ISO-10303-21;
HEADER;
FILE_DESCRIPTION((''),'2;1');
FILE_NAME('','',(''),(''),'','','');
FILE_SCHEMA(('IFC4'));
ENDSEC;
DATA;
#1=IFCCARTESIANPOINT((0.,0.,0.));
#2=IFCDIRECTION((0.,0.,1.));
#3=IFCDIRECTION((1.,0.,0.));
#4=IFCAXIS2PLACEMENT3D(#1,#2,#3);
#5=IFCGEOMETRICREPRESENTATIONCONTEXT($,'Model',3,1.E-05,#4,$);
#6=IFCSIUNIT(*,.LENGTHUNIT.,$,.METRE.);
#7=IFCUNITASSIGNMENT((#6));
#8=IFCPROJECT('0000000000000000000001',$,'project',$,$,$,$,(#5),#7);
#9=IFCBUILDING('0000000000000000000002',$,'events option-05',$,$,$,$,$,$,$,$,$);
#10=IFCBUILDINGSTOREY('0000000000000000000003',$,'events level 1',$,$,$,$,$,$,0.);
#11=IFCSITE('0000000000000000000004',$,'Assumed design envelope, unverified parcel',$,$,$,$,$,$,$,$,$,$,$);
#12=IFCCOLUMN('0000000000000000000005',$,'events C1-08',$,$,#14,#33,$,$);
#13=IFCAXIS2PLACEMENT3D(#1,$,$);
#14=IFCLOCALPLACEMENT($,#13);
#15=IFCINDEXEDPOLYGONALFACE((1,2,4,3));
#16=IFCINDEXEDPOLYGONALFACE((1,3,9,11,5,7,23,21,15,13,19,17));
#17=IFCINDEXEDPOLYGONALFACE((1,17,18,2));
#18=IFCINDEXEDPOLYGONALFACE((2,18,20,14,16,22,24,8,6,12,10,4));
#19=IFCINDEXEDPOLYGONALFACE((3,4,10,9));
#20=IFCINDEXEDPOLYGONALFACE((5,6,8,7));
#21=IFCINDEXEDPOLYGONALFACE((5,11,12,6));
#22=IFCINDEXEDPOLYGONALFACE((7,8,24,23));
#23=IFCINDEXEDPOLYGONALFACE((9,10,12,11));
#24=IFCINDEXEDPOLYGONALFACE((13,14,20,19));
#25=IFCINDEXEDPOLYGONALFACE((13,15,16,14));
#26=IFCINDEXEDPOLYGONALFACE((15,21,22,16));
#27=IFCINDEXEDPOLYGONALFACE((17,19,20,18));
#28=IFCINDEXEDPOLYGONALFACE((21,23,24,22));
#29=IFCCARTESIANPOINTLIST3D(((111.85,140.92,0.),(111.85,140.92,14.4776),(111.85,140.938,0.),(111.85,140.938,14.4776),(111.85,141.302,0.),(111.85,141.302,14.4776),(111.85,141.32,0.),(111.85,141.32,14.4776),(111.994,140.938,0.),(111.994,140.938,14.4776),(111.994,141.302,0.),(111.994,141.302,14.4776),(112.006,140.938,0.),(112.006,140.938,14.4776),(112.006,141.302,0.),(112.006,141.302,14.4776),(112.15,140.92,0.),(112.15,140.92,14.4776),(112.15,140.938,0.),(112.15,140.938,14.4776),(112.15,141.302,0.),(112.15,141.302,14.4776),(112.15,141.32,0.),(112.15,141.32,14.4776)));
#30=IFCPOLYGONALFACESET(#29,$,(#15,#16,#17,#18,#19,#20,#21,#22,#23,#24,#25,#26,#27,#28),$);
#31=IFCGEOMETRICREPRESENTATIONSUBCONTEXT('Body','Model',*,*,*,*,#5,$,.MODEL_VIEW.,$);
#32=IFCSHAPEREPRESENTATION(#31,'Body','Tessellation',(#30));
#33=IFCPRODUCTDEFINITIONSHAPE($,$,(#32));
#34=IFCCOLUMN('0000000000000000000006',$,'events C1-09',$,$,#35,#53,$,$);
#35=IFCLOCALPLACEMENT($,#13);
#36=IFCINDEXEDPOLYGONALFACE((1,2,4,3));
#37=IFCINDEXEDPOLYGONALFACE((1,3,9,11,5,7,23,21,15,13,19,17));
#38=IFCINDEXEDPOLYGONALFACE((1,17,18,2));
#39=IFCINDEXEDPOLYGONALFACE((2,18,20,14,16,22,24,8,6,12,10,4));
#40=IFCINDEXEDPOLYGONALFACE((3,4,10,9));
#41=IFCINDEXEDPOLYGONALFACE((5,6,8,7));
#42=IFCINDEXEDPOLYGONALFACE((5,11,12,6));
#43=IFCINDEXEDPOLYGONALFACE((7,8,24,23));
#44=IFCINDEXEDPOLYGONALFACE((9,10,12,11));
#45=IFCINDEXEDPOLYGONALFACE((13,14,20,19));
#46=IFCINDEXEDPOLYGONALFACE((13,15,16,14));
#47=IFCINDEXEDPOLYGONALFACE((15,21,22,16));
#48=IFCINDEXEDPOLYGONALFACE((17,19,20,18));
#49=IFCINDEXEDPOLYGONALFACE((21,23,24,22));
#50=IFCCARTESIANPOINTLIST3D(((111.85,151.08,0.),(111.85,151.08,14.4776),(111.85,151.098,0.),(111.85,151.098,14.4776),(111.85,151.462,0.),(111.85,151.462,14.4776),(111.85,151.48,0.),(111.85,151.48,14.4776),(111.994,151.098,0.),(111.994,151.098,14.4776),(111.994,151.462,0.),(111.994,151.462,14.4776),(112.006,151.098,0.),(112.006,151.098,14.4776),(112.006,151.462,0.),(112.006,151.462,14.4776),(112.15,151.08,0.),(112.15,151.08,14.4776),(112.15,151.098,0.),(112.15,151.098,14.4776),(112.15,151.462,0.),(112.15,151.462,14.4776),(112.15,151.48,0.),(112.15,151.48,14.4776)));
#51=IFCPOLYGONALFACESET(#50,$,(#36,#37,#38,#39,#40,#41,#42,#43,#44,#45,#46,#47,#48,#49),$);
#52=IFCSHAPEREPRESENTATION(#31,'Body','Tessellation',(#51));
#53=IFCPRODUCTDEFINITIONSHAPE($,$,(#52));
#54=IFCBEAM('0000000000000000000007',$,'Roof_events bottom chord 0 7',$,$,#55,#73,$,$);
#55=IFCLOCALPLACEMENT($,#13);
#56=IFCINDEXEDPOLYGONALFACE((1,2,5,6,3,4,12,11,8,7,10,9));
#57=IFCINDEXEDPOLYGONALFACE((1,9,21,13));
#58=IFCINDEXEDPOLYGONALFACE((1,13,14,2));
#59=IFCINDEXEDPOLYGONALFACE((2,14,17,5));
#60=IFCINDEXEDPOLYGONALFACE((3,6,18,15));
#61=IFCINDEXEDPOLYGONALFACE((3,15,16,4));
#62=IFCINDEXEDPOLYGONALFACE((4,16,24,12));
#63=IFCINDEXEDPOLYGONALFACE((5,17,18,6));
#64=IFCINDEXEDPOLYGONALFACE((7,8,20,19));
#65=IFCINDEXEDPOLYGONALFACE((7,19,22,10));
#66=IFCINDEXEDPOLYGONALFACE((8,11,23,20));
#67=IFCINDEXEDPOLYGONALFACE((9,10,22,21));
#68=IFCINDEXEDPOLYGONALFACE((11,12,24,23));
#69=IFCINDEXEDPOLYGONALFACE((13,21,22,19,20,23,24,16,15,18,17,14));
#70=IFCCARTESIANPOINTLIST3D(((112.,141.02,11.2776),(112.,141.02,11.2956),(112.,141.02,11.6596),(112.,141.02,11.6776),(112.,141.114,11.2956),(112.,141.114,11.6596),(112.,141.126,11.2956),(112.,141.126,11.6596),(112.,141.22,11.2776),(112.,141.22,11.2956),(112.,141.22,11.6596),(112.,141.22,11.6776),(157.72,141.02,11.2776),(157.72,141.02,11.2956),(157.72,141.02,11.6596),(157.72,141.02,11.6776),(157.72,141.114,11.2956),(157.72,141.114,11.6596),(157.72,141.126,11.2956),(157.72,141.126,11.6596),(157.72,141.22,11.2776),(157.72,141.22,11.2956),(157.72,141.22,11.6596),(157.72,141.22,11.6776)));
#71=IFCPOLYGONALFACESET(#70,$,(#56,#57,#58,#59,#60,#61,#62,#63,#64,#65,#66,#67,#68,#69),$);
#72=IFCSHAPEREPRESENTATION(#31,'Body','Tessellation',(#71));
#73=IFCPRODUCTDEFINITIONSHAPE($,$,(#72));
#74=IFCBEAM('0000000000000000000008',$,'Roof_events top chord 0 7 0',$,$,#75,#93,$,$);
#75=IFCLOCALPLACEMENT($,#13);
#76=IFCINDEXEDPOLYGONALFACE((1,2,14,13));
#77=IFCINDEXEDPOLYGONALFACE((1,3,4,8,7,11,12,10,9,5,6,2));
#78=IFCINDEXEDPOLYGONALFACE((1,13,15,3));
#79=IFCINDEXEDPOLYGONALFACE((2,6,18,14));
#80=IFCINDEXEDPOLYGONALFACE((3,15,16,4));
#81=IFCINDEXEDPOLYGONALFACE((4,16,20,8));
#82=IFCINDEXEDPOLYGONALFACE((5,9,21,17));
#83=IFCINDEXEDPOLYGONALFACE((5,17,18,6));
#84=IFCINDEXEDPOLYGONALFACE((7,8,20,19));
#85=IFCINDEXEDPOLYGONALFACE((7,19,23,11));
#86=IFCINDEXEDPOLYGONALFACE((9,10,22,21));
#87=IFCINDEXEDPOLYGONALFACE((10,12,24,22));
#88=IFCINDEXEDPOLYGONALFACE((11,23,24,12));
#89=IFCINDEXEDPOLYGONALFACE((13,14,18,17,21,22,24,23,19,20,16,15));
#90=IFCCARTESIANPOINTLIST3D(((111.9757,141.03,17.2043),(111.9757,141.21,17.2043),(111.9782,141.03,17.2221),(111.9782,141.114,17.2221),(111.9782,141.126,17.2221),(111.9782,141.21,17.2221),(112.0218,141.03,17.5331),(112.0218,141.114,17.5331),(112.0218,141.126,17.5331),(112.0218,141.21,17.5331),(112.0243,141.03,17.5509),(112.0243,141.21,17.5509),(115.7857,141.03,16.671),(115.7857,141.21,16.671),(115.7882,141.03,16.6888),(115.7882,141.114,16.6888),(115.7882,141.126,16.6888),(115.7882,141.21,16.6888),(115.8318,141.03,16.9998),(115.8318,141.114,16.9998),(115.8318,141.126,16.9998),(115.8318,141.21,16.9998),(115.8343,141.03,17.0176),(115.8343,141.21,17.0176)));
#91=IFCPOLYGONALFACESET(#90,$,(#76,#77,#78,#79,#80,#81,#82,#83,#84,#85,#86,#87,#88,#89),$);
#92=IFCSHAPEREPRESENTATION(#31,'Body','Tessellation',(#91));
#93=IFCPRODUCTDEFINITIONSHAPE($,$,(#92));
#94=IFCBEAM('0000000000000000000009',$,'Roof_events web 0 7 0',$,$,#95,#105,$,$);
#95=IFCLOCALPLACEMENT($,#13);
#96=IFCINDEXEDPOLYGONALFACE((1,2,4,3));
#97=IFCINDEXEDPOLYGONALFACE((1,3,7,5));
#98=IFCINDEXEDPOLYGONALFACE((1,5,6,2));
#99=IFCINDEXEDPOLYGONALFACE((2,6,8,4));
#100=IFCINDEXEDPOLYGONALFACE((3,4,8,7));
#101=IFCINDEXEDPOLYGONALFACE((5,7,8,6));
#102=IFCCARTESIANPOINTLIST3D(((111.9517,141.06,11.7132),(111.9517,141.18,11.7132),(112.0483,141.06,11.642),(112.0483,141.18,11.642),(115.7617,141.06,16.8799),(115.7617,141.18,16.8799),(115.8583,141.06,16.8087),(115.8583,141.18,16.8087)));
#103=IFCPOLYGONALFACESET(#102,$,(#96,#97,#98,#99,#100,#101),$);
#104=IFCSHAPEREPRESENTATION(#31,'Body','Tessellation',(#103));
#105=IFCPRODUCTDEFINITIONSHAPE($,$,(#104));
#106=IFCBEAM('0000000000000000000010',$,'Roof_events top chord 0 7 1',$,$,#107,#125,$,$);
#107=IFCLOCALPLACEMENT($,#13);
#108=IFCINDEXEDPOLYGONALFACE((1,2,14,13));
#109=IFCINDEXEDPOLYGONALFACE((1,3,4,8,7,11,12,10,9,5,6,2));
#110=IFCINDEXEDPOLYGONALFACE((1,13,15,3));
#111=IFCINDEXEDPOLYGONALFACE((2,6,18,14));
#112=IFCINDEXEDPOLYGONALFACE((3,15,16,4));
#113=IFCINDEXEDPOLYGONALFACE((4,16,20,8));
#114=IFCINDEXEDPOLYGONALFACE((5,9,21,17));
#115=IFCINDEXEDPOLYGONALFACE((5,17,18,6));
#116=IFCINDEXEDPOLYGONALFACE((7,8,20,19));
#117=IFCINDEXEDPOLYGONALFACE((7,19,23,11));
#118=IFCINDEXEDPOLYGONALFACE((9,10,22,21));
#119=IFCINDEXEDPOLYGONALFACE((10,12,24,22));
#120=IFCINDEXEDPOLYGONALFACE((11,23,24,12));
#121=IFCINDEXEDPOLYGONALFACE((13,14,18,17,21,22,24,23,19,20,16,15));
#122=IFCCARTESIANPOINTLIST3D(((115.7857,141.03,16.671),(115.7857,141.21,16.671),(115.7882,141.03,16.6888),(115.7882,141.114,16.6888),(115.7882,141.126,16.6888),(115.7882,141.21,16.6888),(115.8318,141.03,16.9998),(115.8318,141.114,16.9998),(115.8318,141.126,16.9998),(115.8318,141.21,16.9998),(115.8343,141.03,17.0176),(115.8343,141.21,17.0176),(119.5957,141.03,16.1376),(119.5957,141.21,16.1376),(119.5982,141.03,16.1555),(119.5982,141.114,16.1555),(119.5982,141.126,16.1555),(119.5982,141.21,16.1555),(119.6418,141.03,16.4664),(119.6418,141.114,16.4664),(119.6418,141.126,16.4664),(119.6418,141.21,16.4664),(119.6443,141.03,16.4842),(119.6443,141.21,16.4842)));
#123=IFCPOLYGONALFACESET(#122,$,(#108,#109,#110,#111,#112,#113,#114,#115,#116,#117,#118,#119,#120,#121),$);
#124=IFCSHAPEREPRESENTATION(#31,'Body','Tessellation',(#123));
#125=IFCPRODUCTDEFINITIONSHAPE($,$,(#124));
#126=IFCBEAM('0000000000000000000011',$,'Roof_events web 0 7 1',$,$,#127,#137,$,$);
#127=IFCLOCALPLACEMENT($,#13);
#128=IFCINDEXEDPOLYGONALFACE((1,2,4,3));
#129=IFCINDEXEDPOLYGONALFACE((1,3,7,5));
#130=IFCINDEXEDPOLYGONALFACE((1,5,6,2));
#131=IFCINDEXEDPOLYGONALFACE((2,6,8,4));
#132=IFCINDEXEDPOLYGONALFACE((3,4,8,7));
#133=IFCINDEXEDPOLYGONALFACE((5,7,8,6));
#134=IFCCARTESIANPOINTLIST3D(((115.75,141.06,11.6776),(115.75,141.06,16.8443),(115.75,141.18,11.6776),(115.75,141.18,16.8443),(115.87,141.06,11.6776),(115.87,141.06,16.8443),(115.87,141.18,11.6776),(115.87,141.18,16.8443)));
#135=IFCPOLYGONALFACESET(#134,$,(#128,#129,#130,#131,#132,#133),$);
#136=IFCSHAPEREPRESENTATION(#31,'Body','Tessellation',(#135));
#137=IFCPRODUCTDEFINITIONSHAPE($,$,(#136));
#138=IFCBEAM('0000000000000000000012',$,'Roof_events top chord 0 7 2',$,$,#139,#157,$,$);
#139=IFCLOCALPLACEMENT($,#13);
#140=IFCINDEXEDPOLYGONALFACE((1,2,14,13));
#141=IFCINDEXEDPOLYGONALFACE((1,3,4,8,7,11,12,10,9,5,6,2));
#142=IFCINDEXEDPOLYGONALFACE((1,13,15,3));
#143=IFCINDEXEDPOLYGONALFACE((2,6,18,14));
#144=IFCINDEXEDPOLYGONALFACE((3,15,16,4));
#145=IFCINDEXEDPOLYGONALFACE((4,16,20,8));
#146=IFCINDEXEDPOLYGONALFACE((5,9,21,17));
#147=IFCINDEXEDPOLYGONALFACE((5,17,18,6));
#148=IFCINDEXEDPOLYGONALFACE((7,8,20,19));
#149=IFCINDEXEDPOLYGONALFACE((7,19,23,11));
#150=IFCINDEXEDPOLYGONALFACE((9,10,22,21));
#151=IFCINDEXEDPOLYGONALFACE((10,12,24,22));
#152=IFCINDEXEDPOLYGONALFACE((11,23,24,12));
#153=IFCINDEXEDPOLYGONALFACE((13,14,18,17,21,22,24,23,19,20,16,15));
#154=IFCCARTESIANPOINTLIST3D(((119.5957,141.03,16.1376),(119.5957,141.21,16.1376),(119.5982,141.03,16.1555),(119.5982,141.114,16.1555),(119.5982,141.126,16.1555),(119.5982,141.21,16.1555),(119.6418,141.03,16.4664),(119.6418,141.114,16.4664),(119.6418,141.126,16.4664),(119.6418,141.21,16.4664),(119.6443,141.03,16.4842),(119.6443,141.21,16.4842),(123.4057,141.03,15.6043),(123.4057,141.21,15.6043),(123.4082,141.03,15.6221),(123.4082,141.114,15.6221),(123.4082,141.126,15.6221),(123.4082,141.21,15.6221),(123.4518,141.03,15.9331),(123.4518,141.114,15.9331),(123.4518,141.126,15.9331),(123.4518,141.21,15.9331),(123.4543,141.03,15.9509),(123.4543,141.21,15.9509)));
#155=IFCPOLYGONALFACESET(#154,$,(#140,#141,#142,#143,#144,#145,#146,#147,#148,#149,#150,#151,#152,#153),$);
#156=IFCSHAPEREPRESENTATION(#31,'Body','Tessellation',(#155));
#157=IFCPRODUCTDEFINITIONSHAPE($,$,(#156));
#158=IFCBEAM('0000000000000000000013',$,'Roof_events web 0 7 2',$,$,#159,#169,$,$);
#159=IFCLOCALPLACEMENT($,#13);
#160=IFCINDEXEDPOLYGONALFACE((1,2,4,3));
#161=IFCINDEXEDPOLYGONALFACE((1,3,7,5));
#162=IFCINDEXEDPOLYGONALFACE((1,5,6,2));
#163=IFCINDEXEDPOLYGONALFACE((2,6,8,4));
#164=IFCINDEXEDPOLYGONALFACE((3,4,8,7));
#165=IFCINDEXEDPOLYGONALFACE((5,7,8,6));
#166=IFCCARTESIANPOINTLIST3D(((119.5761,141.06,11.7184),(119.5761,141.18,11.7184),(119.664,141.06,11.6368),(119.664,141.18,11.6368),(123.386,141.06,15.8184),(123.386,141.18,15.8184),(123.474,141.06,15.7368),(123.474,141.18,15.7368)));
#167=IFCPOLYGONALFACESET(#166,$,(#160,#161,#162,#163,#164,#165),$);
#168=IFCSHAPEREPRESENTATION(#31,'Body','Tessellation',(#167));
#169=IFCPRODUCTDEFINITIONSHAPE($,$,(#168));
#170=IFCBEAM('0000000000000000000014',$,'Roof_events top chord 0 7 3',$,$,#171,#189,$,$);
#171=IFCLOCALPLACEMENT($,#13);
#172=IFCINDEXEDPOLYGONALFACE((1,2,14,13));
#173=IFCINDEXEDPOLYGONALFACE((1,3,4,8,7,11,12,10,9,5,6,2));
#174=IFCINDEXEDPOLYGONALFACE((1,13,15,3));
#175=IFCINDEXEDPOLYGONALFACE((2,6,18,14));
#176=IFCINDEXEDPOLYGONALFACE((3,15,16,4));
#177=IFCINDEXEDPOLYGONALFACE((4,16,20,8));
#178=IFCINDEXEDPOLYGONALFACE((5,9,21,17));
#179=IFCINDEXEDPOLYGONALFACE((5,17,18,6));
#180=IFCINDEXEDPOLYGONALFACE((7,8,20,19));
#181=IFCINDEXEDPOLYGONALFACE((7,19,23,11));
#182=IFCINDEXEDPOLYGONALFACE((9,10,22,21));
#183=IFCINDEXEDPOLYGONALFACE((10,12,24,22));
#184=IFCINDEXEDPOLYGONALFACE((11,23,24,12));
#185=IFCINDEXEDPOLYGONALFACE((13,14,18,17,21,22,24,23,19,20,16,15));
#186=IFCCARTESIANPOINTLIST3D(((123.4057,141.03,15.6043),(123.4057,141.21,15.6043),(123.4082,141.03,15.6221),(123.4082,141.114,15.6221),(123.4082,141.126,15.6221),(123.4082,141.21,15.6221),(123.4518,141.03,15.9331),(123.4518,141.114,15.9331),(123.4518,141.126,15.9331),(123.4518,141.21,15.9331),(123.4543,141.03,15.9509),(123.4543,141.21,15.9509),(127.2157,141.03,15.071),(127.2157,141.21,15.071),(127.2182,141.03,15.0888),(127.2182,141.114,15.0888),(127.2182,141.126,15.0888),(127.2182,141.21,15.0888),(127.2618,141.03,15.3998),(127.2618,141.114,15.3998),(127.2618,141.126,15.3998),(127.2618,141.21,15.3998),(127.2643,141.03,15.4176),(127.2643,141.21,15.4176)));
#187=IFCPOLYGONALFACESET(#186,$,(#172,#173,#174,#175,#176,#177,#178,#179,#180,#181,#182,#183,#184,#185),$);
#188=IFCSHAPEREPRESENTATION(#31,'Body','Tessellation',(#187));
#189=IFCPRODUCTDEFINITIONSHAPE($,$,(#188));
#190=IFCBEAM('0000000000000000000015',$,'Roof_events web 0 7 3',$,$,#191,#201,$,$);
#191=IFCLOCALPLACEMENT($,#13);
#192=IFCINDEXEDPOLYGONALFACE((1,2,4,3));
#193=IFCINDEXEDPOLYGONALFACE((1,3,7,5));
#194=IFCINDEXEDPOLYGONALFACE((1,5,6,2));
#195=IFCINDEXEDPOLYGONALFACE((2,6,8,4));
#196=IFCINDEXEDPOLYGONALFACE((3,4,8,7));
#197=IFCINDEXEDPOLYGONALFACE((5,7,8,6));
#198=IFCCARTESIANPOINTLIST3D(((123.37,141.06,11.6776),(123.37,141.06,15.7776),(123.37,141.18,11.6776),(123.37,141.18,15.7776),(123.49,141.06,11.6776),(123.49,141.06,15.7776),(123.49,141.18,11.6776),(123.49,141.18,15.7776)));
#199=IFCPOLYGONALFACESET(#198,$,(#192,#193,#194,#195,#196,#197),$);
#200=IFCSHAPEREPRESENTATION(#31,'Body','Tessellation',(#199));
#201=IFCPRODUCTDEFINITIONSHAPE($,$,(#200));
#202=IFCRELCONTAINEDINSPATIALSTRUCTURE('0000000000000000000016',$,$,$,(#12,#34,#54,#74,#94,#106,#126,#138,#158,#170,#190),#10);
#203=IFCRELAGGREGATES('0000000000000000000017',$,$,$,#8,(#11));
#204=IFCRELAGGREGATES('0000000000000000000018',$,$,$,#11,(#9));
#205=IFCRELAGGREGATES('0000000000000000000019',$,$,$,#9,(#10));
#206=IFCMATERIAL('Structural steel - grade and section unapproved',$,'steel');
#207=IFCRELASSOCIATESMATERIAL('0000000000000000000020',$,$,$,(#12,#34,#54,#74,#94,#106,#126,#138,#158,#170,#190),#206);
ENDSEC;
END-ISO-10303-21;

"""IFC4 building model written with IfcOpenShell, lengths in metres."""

from ifc_helpers import new_model, si_unit, frame, origin_with_axes, place, context, subcontext, project, spatial, rectangle, i_section, extrude, material, element, save


model = new_model("IFC4")

# Units and contexts
model_context = context("Model", 3, precision=1e-05, world=origin_with_axes())
body_context = subcontext(model_context, "Body", "Model", "MODEL_VIEW")
ifc_project = project(units=[si_unit("LENGTHUNIT", "METRE")], contexts=[model_context])

# Site, building, storey
site = spatial("IfcSite", under=ifc_project, Name="Assumed design envelope, unverified parcel")
building = spatial("IfcBuilding", under=site, Name="events option-05")
storey = spatial("IfcBuildingStorey", under=building, Name="events level 1", Elevation=0.0)

# Columns
ifc_material_1 = material(Name="Structural steel - grade and section unapproved", Category="steel")
for number, where, z_axis, x_axis, name in (
    (1, (112.0, 141.12, 0.0), (0.0, 0.0, 1.0), (-1.0, 0.0, 0.0), "events C1-08"),
    (2, (112.0, 151.28, 0.0), (0.0, 0.0, 1.0), (-1.0, 0.0, 0.0), "events C1-09"),
):
    element("IfcColumn", number, at=place(None, frame(where, z_axis=z_axis, x_axis=x_axis)), inside=storey, material=ifc_material_1, Name=name, context=body_context, shape_type="SweptSolid", body=[
        extrude(i_section(OverallWidth=0.3, OverallDepth=0.4, WebThickness=0.012, FlangeThickness=0.018, FilletRadius=0.0), origin_with_axes(), (0.0, 0.0, 1.0), 14.4776),
    ])

# Beams
beam_1_placement = place(None, frame((112.0, 141.12, 11.4776), z_axis=(1.0, 0.0, 0.0), x_axis=(0.0, 1.0, 0.0)))
element("IfcBeam", 3, at=beam_1_placement, inside=storey, material=ifc_material_1, Name="Roof_events bottom chord 0 7", context=body_context, shape_type="SweptSolid", body=[
    extrude(i_section(OverallWidth=0.2, OverallDepth=0.4, WebThickness=0.012, FlangeThickness=0.018, FilletRadius=0.0), origin_with_axes(), (0.0, 0.0, 1.0), 45.72),
])
beam_2_placement = place(None, frame((112.0, 141.12, 17.3776), z_axis=(0.990344, 0.0, -0.138631), x_axis=(0.0, 1.0, 0.0)))
element("IfcBeam", 4, at=beam_2_placement, inside=storey, material=ifc_material_1, Name="Roof_events top chord 0 7 0", context=body_context, shape_type="SweptSolid", body=[
    extrude(i_section(OverallWidth=0.18, OverallDepth=0.35, WebThickness=0.012, FlangeThickness=0.018, FilletRadius=0.0), origin_with_axes(), (0.0, 0.0, 1.0), 3.8471),
])
beam_3_placement = place(None, frame((112.0, 141.12, 11.6776), z_axis=(0.5935, 0.0, 0.804834), x_axis=(0.0, 1.0, 0.0)))
element("IfcBeam", 5, at=beam_3_placement, inside=storey, material=ifc_material_1, Name="Roof_events web 0 7 0", context=body_context, shape_type="SweptSolid", body=[
    extrude(rectangle(XDim=0.12, YDim=0.12), origin_with_axes(), (0.0, 0.0, 1.0), 6.4195),
])
beam_4_placement = place(None, frame((115.81, 141.12, 16.8443), z_axis=(0.990344, 0.0, -0.138631), x_axis=(0.0, 1.0, 0.0)))
element("IfcBeam", 6, at=beam_4_placement, inside=storey, material=ifc_material_1, Name="Roof_events top chord 0 7 1", context=body_context, shape_type="SweptSolid", body=[
    extrude(i_section(OverallWidth=0.18, OverallDepth=0.35, WebThickness=0.012, FlangeThickness=0.018, FilletRadius=0.0), origin_with_axes(), (0.0, 0.0, 1.0), 3.8472),
])
beam_5_placement = place(None, frame((115.81, 141.12, 11.6776), z_axis=(0.0, 0.0, 1.0), x_axis=(-1.0, 0.0, 0.0)))
element("IfcBeam", 7, at=beam_5_placement, inside=storey, material=ifc_material_1, Name="Roof_events web 0 7 1", context=body_context, shape_type="SweptSolid", body=[
    extrude(rectangle(XDim=0.12, YDim=0.12), origin_with_axes(), (0.0, 0.0, 1.0), 5.1667),
])
beam_6_placement = place(None, frame((119.62, 141.12, 16.3109), z_axis=(0.990344, 0.0, -0.138631), x_axis=(0.0, 1.0, 0.0)))
element("IfcBeam", 8, at=beam_6_placement, inside=storey, material=ifc_material_1, Name="Roof_events top chord 0 7 2", context=body_context, shape_type="SweptSolid", body=[
    extrude(i_section(OverallWidth=0.18, OverallDepth=0.35, WebThickness=0.012, FlangeThickness=0.018, FilletRadius=0.0), origin_with_axes(), (0.0, 0.0, 1.0), 3.8471),
])
beam_7_placement = place(None, frame((119.62, 141.12, 11.6776), z_axis=(0.680725, 0.0, 0.732539), x_axis=(0.0, 1.0, 0.0)))
element("IfcBeam", 9, at=beam_7_placement, inside=storey, material=ifc_material_1, Name="Roof_events web 0 7 2", context=body_context, shape_type="SweptSolid", body=[
    extrude(rectangle(XDim=0.12, YDim=0.12), origin_with_axes(), (0.0, 0.0, 1.0), 5.597),
])
beam_8_placement = place(None, frame((123.43, 141.12, 15.7776), z_axis=(0.990344, 0.0, -0.138631), x_axis=(0.0, 1.0, 0.0)))
element("IfcBeam", 10, at=beam_8_placement, inside=storey, material=ifc_material_1, Name="Roof_events top chord 0 7 3", context=body_context, shape_type="SweptSolid", body=[
    extrude(i_section(OverallWidth=0.18, OverallDepth=0.35, WebThickness=0.012, FlangeThickness=0.018, FilletRadius=0.0), origin_with_axes(), (0.0, 0.0, 1.0), 3.8471),
])
beam_9_placement = place(None, frame((123.43, 141.12, 11.6776), z_axis=(0.0, 0.0, 1.0), x_axis=(-1.0, 0.0, 0.0)))
element("IfcBeam", 11, at=beam_9_placement, inside=storey, material=ifc_material_1, Name="Roof_events web 0 7 3", context=body_context, shape_type="SweptSolid", body=[
    extrude(rectangle(XDim=0.12, YDim=0.12), origin_with_axes(), (0.0, 0.0, 1.0), 4.1),
])

save(model, "model.ifc")
